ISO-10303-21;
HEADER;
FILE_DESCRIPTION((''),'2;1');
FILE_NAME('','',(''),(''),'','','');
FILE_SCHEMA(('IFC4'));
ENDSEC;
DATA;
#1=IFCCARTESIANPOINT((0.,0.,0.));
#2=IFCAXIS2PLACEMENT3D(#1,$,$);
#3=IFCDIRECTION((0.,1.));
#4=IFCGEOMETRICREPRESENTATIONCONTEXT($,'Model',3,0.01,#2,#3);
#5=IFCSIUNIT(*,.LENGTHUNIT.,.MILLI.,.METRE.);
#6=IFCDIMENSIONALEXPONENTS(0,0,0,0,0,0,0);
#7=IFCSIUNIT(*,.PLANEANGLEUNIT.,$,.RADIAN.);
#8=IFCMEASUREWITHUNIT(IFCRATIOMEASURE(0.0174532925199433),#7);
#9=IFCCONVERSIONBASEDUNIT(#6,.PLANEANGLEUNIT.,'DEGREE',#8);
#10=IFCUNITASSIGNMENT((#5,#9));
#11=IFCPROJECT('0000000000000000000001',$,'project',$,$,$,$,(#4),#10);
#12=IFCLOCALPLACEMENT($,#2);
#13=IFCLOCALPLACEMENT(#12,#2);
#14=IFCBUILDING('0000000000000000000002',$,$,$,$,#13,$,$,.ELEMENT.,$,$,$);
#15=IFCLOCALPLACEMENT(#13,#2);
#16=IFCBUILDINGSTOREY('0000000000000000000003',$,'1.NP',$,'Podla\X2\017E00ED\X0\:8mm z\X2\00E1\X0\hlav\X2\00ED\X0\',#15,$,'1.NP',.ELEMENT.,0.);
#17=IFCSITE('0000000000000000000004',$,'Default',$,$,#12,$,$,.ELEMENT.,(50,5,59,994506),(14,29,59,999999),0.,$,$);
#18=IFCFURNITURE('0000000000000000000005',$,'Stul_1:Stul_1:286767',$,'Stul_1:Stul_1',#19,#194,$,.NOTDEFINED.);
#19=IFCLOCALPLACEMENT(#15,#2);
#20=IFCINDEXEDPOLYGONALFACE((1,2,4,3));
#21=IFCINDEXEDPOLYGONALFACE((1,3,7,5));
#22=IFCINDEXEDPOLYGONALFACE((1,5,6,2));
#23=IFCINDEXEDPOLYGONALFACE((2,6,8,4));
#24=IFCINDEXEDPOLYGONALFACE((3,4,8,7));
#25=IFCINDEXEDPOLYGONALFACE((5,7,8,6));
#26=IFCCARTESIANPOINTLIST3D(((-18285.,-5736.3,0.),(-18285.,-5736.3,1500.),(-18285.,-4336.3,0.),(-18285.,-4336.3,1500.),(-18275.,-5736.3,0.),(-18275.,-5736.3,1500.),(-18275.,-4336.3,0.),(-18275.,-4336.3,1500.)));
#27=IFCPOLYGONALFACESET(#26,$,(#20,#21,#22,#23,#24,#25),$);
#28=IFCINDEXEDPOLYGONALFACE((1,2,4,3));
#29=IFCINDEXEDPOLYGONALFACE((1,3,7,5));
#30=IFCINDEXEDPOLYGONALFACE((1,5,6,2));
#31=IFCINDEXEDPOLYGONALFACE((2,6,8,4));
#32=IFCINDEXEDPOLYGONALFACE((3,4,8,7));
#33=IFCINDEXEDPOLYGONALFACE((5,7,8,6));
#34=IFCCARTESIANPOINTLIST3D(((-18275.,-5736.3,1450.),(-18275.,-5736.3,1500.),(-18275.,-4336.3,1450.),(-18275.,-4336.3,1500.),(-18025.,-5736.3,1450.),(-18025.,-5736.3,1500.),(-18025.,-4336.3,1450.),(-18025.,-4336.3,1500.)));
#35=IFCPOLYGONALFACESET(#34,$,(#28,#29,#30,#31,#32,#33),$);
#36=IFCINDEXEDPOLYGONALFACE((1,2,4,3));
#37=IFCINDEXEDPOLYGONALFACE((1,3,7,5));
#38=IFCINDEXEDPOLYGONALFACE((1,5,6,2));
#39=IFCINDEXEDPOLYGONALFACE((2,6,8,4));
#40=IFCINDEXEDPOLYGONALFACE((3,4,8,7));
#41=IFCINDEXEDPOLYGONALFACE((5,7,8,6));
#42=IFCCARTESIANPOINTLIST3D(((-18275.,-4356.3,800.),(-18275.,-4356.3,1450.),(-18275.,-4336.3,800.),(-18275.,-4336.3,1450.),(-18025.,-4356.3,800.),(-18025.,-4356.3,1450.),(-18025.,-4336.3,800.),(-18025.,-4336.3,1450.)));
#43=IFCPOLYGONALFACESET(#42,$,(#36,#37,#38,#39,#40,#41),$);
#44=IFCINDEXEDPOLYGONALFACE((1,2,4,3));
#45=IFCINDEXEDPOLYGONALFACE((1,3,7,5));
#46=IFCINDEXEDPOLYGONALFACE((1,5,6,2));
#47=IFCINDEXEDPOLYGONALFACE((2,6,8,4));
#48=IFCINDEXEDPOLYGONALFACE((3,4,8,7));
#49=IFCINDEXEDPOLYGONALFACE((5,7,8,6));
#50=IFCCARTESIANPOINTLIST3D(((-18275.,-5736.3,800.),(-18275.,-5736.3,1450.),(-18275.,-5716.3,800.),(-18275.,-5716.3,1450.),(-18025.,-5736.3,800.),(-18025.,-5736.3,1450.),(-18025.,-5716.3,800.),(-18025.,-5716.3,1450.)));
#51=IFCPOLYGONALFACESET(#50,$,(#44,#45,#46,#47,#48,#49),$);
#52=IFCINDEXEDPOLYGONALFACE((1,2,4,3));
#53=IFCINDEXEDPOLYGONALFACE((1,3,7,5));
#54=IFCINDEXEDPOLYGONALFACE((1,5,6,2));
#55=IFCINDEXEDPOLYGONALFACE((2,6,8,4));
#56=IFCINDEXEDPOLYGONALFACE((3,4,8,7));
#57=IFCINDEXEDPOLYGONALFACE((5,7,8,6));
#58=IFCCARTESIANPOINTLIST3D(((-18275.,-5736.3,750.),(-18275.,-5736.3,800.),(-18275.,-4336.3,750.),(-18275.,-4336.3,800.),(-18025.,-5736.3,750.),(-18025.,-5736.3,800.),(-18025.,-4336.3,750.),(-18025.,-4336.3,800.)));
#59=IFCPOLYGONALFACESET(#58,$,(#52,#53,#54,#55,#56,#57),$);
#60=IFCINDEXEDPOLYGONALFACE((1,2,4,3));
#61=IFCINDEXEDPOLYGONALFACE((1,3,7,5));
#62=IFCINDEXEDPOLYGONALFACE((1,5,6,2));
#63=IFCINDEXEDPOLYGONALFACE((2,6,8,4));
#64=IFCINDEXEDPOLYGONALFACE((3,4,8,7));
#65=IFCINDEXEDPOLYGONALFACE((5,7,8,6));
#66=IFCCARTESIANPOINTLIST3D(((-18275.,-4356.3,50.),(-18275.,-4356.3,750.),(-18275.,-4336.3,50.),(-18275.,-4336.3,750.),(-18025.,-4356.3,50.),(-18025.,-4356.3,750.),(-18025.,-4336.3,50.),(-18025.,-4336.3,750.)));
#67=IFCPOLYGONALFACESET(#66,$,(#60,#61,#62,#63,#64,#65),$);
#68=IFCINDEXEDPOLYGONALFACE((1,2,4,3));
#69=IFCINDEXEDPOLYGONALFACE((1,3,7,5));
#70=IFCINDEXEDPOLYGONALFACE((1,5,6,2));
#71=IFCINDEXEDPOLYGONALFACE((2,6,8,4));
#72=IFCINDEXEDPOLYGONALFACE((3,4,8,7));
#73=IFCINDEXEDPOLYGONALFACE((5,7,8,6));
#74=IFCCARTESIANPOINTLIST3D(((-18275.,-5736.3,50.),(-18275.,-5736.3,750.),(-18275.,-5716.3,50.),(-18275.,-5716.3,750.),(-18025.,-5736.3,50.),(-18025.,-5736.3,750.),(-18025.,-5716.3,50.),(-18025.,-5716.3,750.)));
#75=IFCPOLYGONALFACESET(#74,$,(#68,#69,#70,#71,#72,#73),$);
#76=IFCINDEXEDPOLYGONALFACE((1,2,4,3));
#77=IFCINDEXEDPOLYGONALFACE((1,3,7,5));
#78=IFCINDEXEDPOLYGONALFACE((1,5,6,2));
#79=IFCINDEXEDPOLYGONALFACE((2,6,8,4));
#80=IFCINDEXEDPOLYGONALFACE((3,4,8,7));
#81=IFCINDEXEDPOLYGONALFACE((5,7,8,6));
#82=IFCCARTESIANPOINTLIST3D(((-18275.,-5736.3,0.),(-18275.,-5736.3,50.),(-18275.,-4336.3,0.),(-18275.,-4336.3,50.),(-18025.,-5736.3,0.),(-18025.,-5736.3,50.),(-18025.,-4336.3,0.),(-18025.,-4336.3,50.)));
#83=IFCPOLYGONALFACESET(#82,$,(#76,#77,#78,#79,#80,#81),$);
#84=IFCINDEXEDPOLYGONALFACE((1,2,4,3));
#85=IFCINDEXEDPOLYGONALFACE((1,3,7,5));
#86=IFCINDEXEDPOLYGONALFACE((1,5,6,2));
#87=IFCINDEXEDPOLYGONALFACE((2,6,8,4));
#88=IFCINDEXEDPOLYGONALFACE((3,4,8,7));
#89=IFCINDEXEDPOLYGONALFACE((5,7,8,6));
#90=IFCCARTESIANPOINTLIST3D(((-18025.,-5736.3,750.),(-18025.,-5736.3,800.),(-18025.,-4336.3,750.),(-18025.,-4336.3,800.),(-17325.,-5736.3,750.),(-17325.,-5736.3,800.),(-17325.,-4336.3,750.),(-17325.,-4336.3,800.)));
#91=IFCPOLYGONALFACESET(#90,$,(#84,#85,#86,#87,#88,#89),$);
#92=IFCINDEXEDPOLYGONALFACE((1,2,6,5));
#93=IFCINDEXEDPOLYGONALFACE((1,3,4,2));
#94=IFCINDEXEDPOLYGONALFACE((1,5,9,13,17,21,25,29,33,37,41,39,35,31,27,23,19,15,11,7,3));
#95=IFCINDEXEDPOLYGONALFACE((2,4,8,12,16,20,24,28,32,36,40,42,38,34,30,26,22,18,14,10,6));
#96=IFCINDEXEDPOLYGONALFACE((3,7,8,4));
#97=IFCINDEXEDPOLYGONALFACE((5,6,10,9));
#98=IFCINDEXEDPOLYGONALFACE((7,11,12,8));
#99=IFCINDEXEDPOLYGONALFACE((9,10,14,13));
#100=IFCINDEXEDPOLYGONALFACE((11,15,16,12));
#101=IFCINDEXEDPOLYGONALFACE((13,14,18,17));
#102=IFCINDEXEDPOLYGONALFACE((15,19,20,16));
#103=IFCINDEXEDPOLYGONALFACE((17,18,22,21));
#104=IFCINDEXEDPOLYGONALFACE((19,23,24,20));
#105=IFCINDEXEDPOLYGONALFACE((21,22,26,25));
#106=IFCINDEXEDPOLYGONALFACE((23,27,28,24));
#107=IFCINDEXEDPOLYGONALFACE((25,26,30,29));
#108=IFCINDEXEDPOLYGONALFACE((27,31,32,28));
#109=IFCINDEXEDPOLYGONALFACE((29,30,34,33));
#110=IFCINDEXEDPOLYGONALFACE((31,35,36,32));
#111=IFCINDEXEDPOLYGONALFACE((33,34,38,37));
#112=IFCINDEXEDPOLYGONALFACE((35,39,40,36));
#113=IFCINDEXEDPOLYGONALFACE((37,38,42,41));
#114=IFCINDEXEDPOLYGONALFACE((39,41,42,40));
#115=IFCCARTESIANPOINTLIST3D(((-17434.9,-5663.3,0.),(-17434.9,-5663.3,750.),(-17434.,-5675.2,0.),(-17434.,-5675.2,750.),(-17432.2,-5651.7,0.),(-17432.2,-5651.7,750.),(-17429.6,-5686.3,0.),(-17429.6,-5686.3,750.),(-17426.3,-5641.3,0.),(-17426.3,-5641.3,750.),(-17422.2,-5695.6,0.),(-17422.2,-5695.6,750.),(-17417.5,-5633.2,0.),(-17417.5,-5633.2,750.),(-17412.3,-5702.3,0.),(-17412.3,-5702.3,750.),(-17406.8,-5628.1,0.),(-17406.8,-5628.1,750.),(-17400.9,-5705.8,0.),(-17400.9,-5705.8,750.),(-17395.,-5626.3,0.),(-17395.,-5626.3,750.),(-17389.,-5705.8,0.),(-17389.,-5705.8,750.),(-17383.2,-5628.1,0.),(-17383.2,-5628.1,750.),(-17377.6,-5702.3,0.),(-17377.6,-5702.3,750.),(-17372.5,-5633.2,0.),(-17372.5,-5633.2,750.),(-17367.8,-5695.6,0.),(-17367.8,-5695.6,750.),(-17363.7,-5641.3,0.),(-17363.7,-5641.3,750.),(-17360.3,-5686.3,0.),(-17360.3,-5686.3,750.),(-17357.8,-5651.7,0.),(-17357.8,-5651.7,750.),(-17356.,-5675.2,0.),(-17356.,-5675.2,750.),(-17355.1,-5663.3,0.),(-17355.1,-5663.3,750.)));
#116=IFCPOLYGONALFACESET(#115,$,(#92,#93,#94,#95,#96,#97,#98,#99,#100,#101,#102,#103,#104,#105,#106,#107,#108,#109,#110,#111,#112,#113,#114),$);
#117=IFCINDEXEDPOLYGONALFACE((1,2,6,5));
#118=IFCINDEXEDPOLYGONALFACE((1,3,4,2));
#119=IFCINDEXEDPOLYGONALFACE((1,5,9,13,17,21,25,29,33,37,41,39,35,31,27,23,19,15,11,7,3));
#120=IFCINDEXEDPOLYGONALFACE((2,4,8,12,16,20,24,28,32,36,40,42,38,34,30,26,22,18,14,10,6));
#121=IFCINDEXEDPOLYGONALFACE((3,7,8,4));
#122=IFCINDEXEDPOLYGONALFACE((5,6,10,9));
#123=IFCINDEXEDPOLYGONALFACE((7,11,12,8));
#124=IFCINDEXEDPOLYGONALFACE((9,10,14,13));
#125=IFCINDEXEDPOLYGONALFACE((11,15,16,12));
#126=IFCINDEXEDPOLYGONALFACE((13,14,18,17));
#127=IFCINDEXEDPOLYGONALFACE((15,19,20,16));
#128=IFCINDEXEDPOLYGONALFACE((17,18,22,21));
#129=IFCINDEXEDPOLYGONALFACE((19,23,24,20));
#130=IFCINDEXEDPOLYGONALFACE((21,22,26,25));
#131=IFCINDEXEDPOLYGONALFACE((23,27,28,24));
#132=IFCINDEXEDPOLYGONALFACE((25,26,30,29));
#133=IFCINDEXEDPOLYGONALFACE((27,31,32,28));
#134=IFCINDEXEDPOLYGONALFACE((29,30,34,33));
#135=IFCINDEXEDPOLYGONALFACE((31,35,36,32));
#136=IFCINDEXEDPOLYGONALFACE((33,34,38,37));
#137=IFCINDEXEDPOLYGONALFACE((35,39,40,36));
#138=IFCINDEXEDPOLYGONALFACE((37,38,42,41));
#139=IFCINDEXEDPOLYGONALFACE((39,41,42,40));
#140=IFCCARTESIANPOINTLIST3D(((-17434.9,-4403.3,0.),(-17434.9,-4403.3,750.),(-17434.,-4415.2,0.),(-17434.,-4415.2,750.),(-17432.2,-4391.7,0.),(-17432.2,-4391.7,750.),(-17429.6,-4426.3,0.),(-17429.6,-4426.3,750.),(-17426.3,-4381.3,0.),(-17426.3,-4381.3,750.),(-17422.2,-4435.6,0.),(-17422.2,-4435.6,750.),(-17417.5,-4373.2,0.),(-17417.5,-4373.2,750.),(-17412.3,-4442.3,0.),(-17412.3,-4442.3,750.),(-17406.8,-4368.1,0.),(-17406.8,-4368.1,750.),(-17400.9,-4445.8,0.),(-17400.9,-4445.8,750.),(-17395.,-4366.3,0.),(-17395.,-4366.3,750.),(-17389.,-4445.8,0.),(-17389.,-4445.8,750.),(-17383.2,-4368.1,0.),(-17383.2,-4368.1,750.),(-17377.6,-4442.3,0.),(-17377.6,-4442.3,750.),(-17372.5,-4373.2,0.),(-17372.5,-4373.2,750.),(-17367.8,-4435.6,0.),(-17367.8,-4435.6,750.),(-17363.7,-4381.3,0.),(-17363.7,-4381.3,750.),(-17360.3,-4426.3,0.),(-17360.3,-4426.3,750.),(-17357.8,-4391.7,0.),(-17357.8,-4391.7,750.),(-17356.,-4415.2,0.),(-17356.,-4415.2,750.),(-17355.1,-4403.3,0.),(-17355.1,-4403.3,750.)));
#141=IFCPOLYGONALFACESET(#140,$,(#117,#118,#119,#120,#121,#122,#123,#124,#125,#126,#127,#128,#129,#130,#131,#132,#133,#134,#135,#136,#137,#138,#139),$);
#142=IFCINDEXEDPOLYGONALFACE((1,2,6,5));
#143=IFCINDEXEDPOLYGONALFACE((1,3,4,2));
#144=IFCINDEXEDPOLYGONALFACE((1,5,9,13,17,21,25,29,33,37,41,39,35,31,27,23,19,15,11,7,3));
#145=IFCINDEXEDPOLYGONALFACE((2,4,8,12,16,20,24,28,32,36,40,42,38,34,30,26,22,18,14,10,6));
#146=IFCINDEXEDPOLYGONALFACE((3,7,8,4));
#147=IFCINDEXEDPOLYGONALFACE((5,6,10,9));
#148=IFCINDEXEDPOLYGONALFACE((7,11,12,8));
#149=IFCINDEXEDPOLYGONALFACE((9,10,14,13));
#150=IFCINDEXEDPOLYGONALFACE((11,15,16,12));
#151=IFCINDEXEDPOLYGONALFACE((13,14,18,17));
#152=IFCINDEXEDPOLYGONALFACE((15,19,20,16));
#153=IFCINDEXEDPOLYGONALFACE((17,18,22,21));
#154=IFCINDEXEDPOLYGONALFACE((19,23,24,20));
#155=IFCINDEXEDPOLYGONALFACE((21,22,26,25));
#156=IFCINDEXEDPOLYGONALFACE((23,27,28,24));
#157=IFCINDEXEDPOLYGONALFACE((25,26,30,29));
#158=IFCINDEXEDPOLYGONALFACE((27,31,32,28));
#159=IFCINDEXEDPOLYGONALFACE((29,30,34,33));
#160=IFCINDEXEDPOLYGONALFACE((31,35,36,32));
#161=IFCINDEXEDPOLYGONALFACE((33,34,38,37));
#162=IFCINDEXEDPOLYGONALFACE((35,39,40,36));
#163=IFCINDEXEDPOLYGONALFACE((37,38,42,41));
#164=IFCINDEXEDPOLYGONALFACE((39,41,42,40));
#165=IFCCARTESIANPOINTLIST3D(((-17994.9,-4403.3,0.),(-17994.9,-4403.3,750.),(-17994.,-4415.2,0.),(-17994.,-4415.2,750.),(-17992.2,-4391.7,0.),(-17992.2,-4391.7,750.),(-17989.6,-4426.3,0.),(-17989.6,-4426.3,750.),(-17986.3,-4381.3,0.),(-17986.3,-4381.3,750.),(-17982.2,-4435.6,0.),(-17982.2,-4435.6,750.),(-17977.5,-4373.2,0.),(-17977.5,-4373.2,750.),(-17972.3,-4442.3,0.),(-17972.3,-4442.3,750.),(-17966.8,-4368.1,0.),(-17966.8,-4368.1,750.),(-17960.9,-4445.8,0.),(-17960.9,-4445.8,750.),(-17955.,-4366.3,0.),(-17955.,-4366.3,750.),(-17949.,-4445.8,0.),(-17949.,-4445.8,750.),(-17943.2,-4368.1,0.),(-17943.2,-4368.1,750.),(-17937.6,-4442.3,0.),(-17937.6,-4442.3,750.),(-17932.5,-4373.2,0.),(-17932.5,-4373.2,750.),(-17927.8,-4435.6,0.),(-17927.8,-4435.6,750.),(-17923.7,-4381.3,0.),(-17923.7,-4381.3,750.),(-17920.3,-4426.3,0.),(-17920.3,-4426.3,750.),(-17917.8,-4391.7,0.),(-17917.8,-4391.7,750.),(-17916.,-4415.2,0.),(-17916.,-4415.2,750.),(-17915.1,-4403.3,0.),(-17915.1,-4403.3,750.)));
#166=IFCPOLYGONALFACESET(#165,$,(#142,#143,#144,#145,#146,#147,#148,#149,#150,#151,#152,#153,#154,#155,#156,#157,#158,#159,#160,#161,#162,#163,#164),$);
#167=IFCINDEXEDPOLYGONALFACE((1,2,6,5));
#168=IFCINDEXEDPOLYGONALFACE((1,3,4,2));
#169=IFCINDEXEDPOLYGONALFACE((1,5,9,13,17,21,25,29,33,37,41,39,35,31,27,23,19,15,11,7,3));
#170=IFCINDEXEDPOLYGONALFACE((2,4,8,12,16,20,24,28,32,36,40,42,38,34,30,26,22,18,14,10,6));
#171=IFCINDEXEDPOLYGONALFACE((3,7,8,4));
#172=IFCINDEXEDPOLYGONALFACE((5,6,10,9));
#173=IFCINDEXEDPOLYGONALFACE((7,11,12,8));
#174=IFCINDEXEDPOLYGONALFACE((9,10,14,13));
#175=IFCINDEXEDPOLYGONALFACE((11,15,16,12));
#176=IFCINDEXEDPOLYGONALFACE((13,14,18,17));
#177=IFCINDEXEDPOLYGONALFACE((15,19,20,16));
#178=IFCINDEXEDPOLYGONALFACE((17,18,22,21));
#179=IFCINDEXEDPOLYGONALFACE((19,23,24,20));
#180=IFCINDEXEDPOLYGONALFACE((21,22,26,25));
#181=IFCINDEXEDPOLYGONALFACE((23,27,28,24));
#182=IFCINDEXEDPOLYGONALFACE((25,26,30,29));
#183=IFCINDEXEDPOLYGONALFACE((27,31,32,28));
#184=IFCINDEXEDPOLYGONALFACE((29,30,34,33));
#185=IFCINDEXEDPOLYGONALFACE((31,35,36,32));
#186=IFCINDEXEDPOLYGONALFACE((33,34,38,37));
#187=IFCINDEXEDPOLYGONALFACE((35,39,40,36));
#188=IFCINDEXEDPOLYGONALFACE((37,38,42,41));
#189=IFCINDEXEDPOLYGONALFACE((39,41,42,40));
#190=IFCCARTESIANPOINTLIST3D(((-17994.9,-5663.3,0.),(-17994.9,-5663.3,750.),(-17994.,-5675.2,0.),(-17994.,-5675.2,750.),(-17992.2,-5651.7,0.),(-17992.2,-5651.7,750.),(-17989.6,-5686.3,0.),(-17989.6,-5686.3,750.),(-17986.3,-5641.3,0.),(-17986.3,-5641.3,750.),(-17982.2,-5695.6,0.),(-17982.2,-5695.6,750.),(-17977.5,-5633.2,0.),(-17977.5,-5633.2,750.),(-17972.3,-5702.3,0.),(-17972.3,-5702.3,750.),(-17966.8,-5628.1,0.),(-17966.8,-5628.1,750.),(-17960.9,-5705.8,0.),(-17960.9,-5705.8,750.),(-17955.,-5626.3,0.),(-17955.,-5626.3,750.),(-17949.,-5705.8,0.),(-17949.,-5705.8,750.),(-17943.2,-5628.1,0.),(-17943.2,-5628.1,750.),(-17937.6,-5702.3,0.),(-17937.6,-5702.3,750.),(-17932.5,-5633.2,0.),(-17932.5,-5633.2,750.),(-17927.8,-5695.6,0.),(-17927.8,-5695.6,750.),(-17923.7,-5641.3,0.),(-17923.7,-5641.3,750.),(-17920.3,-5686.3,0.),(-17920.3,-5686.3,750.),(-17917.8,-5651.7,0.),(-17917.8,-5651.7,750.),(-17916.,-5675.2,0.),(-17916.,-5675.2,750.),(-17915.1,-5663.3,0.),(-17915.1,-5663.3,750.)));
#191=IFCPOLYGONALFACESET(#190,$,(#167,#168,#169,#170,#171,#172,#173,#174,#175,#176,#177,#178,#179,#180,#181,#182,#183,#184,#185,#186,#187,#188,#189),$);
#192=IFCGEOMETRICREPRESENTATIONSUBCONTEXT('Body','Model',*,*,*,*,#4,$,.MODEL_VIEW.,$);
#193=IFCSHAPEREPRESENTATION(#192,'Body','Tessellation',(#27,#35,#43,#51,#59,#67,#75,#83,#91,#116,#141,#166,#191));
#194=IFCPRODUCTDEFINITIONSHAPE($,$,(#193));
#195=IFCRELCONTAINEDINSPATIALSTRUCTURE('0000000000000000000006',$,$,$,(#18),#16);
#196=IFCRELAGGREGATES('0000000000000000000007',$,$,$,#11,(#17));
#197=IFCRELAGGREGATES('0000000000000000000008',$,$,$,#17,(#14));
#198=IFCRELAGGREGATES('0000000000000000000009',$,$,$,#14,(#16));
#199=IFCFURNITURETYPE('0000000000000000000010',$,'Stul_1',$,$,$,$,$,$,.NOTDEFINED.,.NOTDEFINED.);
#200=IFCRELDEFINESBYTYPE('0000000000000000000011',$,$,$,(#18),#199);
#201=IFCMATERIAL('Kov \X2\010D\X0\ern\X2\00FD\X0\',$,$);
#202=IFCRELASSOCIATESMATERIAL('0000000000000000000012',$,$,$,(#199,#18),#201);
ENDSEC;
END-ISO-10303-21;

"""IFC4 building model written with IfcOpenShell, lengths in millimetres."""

from ifc_helpers import new_model, entity, si_unit, converted_unit, direction, frame, frame_2d, origin, origin_2d_with_axis, place, context, subcontext, project, spatial, rectangle, circle, extrude, source, transform, mapped, material, type_object, type_shapes, element, save


model = new_model("IFC4")

# Units and contexts
model_context = context("Model", 3, precision=0.01, world=origin(), true_north=direction((0.0, 1.0)))
body_context = subcontext(model_context, "Body", "Model", "MODEL_VIEW")
ifc_project = project(units=[si_unit("LENGTHUNIT", "METRE", prefix="MILLI"), converted_unit("PLANEANGLEUNIT", "DEGREE", entity("IfcRatioMeasure", 0.0174532925199433), si_unit("PLANEANGLEUNIT", "RADIAN"), dimensions=[0, 0, 0, 0, 0, 0, 0])], contexts=[model_context])

# Site, building, storey
site_placement = place(None, origin())
site = spatial("IfcSite", under=ifc_project, at=site_placement, Name="Default", CompositionType="ELEMENT", RefLatitude=(50, 5, 59, 994506), RefLongitude=(14, 29, 59, 999999), RefElevation=0.0)
building_placement = place(site_placement, origin())
building = spatial("IfcBuilding", under=site, at=building_placement, CompositionType="ELEMENT")
storey_placement = place(building_placement, origin())
storey = spatial("IfcBuildingStorey", under=building, at=storey_placement, Name="1.NP", ObjectType="Podlaží:8mm záhlaví", LongName="1.NP", CompositionType="ELEMENT", Elevation=0.0)

# Furniture
ifc_material_1 = material(Name="Kov černý")
furniture_type = type_object("IfcFurnitureType", Name="Stul_1", AssemblyPlace="NOTDEFINED", PredefinedType="NOTDEFINED", material=ifc_material_1)
shared_shape_1 = source(origin(), body_context, "Body", "SweptSolid", [
    extrude(rectangle(XDim=1400.0, YDim=10.0, at=origin_2d_with_axis()), frame((0.0, 605.0, 0.0), z_axis=(0.0, 0.0, 1.0), x_axis=(-1.0, 0.0, 0.0)), (0.0, 0.0, 1.0), 1500.0),
    extrude(rectangle(XDim=1400.0, YDim=250.0, at=frame_2d((0.0, 0.0), x_axis=(1.0, 0.0))), frame((0.0, 475.0, 1450.0), z_axis=(0.0, 0.0, 1.0), x_axis=(-1.0, 0.0, 0.0)), (0.0, 0.0, 1.0), 50.0),
    extrude(rectangle(XDim=20.0, YDim=250.0, at=origin_2d_with_axis()), frame((690.0, 475.0, 800.0), z_axis=(0.0, 0.0, 1.0), x_axis=(-1.0, 0.0, 0.0)), (0.0, 0.0, 1.0), 650.0),
    extrude(rectangle(XDim=20.0, YDim=250.0, at=frame_2d((0.0, 0.0), x_axis=(1.0, 0.0))), frame((-690.0, 475.0, 800.0), z_axis=(0.0, 0.0, 1.0), x_axis=(-1.0, 0.0, 0.0)), (0.0, 0.0, 1.0), 650.0),
    extrude(rectangle(XDim=1400.0, YDim=250.0, at=origin_2d_with_axis()), frame((0.0, 475.0, 750.0), z_axis=(0.0, 0.0, 1.0), x_axis=(-1.0, 0.0, 0.0)), (0.0, 0.0, 1.0), 50.0),
    extrude(rectangle(XDim=20.0, YDim=250.0, at=origin_2d_with_axis()), frame((690.0, 475.0, 50.0), z_axis=(0.0, 0.0, 1.0), x_axis=(-1.0, 0.0, 0.0)), (0.0, 0.0, 1.0), 700.0),
    extrude(rectangle(XDim=20.0, YDim=250.0, at=frame_2d((0.0, 0.0), x_axis=(1.0, 0.0))), frame((-690.0, 475.0, 50.0), z_axis=(0.0, 0.0, 1.0), x_axis=(-1.0, 0.0, 0.0)), (0.0, 0.0, 1.0), 700.0),
    extrude(rectangle(XDim=1400.0, YDim=250.0, at=origin_2d_with_axis()), frame((0.0, 475.0, 0.0), z_axis=(0.0, 0.0, 1.0), x_axis=(-1.0, 0.0, 0.0)), (0.0, 0.0, 1.0), 50.0),
    extrude(rectangle(XDim=1400.0, YDim=700.0, at=origin_2d_with_axis()), frame((0.0, 0.0, 750.0), z_axis=(0.0, 0.0, 1.0), x_axis=(-1.0, 0.0, 0.0)), (0.0, 0.0, 1.0), 50.0),
    extrude(circle(Radius=40.0, at=frame_2d((0.0, 0.0), x_axis=(1.0, 0.0))), frame((-630.0, -280.0, 0.0)), (0.0, 0.0, 1.0), 750.0),
    extrude(circle(Radius=40.0, at=frame_2d((0.0, 0.0), x_axis=(1.0, 0.0))), frame((630.0, -280.0, 0.0)), (0.0, 0.0, 1.0), 750.0),
    extrude(circle(Radius=40.0, at=frame_2d((0.0, 0.0), x_axis=(1.0, 0.0))), frame((630.0, 280.0, 0.0)), (0.0, 0.0, 1.0), 750.0),
    extrude(circle(Radius=40.0, at=frame_2d((0.0, 0.0), x_axis=(1.0, 0.0))), frame((-630.0, 280.0, 0.0)), (0.0, 0.0, 1.0), 750.0),
])
type_shapes(furniture_type, [shared_shape_1])
for number, where, z_axis, x_axis, name in (
    (1, (-17675.0, -5036.3, 0.0), (0.0, 0.0, 1.0), (0.0, 1.0, 0.0), "Stul_1:Stul_1:286767"),
):
    element("IfcFurniture", number, at=place(storey_placement, frame(where, z_axis=z_axis, x_axis=x_axis)), inside=storey, type_object=furniture_type, material=ifc_material_1, Name=name, ObjectType="Stul_1:Stul_1", PredefinedType="NOTDEFINED", context=body_context, shape_type="MappedRepresentation", body=[
        mapped(shared_shape_1, transform((0.0, 0.0, 0.0), scale=1.0)),
    ])

save(model, "model.ifc")
